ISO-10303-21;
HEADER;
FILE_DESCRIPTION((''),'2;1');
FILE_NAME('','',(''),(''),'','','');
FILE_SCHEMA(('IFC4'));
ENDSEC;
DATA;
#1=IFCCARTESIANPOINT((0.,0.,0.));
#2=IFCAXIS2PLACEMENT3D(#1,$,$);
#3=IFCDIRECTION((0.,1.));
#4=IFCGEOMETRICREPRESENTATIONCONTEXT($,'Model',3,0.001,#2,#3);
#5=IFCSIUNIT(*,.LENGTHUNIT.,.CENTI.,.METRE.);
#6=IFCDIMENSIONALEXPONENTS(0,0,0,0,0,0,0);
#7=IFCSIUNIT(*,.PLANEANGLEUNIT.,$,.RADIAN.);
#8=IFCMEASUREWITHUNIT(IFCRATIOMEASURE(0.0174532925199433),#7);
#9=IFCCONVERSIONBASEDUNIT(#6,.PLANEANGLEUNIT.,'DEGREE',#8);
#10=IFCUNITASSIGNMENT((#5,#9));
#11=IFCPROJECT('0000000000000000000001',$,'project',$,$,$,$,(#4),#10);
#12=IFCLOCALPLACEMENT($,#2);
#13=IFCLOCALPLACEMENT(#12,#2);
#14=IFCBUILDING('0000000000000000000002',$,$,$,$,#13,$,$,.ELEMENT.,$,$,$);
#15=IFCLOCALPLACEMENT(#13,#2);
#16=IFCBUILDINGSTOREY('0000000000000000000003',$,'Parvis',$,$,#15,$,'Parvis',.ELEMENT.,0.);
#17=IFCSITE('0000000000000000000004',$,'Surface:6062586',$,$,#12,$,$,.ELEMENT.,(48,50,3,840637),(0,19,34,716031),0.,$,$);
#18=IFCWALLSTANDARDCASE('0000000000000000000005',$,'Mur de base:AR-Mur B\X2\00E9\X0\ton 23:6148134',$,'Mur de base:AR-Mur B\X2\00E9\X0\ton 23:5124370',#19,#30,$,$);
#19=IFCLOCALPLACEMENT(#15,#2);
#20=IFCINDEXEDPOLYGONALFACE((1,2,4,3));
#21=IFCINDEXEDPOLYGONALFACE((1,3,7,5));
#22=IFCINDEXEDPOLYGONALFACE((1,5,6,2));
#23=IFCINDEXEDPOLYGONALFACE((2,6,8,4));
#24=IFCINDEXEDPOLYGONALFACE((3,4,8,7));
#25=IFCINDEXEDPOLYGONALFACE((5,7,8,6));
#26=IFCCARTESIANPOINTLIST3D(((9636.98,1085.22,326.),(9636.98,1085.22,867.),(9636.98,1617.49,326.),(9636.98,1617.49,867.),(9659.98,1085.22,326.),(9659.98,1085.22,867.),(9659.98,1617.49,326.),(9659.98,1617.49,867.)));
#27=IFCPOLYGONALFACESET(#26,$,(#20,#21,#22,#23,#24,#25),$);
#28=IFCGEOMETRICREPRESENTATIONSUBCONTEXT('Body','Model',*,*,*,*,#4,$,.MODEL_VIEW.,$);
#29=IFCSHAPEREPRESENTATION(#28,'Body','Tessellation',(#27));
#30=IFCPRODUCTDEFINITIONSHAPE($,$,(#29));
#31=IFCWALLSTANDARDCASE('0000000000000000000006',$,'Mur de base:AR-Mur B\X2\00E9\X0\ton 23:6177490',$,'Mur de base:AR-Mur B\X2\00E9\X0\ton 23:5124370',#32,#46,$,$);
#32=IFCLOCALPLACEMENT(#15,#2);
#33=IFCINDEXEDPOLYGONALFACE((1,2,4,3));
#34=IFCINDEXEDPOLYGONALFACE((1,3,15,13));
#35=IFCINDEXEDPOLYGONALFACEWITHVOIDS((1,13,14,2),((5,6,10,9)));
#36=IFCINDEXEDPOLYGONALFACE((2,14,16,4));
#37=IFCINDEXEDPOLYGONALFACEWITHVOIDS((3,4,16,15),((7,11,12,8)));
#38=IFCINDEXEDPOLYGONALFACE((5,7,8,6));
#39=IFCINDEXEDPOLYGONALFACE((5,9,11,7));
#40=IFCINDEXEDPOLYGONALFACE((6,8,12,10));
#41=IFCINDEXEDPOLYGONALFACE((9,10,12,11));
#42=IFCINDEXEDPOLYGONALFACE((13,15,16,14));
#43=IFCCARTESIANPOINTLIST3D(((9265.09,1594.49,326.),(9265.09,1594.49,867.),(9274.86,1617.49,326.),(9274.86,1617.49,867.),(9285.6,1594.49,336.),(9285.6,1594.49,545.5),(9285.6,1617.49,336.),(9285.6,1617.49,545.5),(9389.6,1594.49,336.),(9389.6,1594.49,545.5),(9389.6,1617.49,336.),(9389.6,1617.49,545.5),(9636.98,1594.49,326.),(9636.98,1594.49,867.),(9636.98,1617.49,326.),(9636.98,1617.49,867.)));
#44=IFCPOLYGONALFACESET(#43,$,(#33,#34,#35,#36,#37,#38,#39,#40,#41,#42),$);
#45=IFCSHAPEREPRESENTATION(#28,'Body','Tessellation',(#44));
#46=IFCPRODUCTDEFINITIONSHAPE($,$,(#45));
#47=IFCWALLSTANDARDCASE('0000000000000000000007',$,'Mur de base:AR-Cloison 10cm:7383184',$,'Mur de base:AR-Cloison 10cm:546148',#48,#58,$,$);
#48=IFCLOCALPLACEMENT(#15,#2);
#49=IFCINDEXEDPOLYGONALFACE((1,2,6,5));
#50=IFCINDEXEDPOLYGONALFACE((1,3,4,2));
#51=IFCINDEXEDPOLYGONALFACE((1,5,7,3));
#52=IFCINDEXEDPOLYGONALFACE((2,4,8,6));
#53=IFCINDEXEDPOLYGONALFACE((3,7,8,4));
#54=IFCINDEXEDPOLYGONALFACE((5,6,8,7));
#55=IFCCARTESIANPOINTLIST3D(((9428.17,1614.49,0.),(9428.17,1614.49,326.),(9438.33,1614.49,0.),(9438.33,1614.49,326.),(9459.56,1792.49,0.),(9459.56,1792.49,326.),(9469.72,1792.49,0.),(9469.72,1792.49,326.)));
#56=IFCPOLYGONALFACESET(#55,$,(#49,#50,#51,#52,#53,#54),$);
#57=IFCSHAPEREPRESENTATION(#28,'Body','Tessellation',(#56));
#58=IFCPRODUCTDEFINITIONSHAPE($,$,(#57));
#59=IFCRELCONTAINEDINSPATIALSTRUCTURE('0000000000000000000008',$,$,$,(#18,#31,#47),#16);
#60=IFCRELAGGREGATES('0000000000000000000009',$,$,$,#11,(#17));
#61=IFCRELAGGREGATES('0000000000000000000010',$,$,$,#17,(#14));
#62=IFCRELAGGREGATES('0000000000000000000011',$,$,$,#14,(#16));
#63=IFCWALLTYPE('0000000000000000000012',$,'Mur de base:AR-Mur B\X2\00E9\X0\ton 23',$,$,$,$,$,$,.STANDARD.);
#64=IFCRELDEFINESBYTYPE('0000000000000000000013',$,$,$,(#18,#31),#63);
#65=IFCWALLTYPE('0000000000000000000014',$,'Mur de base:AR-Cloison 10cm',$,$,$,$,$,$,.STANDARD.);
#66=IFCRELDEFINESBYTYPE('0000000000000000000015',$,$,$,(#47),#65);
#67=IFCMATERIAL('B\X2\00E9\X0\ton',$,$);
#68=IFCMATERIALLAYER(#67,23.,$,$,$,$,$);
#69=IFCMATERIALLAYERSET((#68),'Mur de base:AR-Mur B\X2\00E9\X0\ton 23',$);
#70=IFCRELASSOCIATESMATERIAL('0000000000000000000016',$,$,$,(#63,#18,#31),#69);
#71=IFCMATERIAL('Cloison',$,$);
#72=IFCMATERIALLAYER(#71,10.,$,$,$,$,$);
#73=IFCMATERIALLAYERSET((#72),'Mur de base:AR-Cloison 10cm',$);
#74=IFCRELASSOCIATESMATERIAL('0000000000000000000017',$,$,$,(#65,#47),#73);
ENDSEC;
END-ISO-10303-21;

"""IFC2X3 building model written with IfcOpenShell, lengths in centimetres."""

from ifc_helpers import new_model, entity, si_unit, converted_unit, direction, frame, frame_2d, origin, place, context, subcontext, project, spatial, polyline, rectangle, outline, extrude, material, layer, layer_set, layer_usage, type_object, element, save


model = new_model("IFC2X3")

# Units and contexts
model_context = context("Model", 3, precision=0.001, world=origin(), true_north=direction((0.0, 1.0)))
body_context = subcontext(model_context, "Body", "Model", "MODEL_VIEW")
ifc_project = project(units=[si_unit("LENGTHUNIT", "METRE", prefix="CENTI"), converted_unit("PLANEANGLEUNIT", "DEGREE", entity("IfcRatioMeasure", 0.0174532925199433), si_unit("PLANEANGLEUNIT", "RADIAN"), dimensions=[0, 0, 0, 0, 0, 0, 0])], contexts=[model_context])

# Site, building, storey
site_placement = place(None, origin())
site = spatial("IfcSite", under=ifc_project, at=site_placement, Name="Surface:6062586", CompositionType="ELEMENT", RefLatitude=(48, 50, 3, 840637), RefLongitude=(0, 19, 34, 716031), RefElevation=0.0)
building_placement = place(site_placement, origin())
building = spatial("IfcBuilding", under=site, at=building_placement, CompositionType="ELEMENT")
storey_placement = place(building_placement, frame((0.0, 0.0, 0.0)))
storey = spatial("IfcBuildingStorey", under=building, at=storey_placement, Name="Parvis", LongName="Parvis", CompositionType="ELEMENT", Elevation=0.0)

# Shared definitions
ifc_material_1 = material(Name="Béton")

# Wall
ifc_layer_1 = layer(ifc_material_1, 23.0)
ifc_layer_set_1 = layer_set([ifc_layer_1], Name="Mur de base:AR-Mur Béton 23")
wall_type_1 = type_object("IfcWallType", Name="Mur de base:AR-Mur Béton 23", PredefinedType="STANDARD", material=ifc_layer_set_1)
ifc_layer_usage_1 = layer_usage(ifc_layer_set_1, "AXIS2", "NEGATIVE", 11.5)
wall_1_placement = place(storey_placement, frame((9648.48, 1617.49, 326.0), z_axis=(0.0, 0.0, 1.0), x_axis=(0.0, -1.0, 0.0)))
element("IfcWallStandardCase", 1, at=wall_1_placement, inside=storey, type_object=wall_type_1, material=ifc_layer_usage_1, Name="Mur de base:AR-Mur Béton 23:6148134", ObjectType="Mur de base:AR-Mur Béton 23:5124370", context=body_context, shape_type="SweptSolid", body=[
    extrude(rectangle(XDim=532.28, YDim=23.0, at=frame_2d((266.14, 0.0), x_axis=(-1.0, 0.0))), origin(), (0.0, 0.0, 1.0), 541.0),
])

# Wall, opening
ifc_layer_usage_2 = layer_usage(ifc_layer_set_1, "AXIS2", "NEGATIVE", 11.5)
wall_2_placement = place(storey_placement, frame((9265.09, 1605.99, 326.0)))
wall_2 = element("IfcWallStandardCase", 2, at=wall_2_placement, inside=storey, type_object=wall_type_1, material=ifc_layer_usage_2, Name="Mur de base:AR-Mur Béton 23:6177490", ObjectType="Mur de base:AR-Mur Béton 23:5124370", context=body_context, shape_type="SweptSolid", body=[
    extrude(outline(polyline([(371.89, -11.5), (371.89, 11.5), (302.32, 11.5), (282.32, 11.5), (9.77, 11.5), (0.0, -11.5), (371.89, -11.5)])), origin(), (0.0, 0.0, 1.0), 541.0),
])
opening_1_placement = place(wall_2_placement, frame((124.51, 11.5, 10.0)))
element("IfcOpeningElement", 3, at=opening_1_placement, cuts=wall_2, ObjectType="Opening", context=body_context, shape_type="SweptSolid", body=[
    extrude(rectangle(XDim=209.5, YDim=104.0, at=frame_2d((104.75, 52.0), x_axis=(1.0, 0.0))), frame((0.0, 0.0, 0.0), z_axis=(0.0, -1.0, 0.0), x_axis=(0.0, 0.0, 1.0)), (0.0, 0.0, 1.0), 23.0),
])

# Wall
ifc_material_2 = material(Name="Cloison")
ifc_layer_2 = layer(ifc_material_2, 10.0)
ifc_layer_set_2 = layer_set([ifc_layer_2], Name="Mur de base:AR-Cloison 10cm")
ifc_layer_usage_3 = layer_usage(ifc_layer_set_2, "AXIS2", "NEGATIVE", 5.0)
wall_type_2 = type_object("IfcWallType", Name="Mur de base:AR-Cloison 10cm", PredefinedType="STANDARD", material=ifc_layer_set_2)
wall_3_placement = place(storey_placement, frame((9433.1, 1613.63, 0.0), z_axis=(0.0, 0.0, 1.0), x_axis=(0.173648, 0.984808, 0.0)))
element("IfcWallStandardCase", 4, at=wall_3_placement, inside=storey, type_object=wall_type_2, material=ifc_layer_usage_3, Name="Mur de base:AR-Cloison 10cm:7383184", ObjectType="Mur de base:AR-Cloison 10cm:546148", context=body_context, shape_type="SweptSolid", body=[
    extrude(outline(polyline([(182.51, -5.0), (180.75, 5.0), (0.0, 5.0), (1.76, -5.0), (182.51, -5.0)])), origin(), (0.0, 0.0, 1.0), 326.0),
])

save(model, "model.ifc")
